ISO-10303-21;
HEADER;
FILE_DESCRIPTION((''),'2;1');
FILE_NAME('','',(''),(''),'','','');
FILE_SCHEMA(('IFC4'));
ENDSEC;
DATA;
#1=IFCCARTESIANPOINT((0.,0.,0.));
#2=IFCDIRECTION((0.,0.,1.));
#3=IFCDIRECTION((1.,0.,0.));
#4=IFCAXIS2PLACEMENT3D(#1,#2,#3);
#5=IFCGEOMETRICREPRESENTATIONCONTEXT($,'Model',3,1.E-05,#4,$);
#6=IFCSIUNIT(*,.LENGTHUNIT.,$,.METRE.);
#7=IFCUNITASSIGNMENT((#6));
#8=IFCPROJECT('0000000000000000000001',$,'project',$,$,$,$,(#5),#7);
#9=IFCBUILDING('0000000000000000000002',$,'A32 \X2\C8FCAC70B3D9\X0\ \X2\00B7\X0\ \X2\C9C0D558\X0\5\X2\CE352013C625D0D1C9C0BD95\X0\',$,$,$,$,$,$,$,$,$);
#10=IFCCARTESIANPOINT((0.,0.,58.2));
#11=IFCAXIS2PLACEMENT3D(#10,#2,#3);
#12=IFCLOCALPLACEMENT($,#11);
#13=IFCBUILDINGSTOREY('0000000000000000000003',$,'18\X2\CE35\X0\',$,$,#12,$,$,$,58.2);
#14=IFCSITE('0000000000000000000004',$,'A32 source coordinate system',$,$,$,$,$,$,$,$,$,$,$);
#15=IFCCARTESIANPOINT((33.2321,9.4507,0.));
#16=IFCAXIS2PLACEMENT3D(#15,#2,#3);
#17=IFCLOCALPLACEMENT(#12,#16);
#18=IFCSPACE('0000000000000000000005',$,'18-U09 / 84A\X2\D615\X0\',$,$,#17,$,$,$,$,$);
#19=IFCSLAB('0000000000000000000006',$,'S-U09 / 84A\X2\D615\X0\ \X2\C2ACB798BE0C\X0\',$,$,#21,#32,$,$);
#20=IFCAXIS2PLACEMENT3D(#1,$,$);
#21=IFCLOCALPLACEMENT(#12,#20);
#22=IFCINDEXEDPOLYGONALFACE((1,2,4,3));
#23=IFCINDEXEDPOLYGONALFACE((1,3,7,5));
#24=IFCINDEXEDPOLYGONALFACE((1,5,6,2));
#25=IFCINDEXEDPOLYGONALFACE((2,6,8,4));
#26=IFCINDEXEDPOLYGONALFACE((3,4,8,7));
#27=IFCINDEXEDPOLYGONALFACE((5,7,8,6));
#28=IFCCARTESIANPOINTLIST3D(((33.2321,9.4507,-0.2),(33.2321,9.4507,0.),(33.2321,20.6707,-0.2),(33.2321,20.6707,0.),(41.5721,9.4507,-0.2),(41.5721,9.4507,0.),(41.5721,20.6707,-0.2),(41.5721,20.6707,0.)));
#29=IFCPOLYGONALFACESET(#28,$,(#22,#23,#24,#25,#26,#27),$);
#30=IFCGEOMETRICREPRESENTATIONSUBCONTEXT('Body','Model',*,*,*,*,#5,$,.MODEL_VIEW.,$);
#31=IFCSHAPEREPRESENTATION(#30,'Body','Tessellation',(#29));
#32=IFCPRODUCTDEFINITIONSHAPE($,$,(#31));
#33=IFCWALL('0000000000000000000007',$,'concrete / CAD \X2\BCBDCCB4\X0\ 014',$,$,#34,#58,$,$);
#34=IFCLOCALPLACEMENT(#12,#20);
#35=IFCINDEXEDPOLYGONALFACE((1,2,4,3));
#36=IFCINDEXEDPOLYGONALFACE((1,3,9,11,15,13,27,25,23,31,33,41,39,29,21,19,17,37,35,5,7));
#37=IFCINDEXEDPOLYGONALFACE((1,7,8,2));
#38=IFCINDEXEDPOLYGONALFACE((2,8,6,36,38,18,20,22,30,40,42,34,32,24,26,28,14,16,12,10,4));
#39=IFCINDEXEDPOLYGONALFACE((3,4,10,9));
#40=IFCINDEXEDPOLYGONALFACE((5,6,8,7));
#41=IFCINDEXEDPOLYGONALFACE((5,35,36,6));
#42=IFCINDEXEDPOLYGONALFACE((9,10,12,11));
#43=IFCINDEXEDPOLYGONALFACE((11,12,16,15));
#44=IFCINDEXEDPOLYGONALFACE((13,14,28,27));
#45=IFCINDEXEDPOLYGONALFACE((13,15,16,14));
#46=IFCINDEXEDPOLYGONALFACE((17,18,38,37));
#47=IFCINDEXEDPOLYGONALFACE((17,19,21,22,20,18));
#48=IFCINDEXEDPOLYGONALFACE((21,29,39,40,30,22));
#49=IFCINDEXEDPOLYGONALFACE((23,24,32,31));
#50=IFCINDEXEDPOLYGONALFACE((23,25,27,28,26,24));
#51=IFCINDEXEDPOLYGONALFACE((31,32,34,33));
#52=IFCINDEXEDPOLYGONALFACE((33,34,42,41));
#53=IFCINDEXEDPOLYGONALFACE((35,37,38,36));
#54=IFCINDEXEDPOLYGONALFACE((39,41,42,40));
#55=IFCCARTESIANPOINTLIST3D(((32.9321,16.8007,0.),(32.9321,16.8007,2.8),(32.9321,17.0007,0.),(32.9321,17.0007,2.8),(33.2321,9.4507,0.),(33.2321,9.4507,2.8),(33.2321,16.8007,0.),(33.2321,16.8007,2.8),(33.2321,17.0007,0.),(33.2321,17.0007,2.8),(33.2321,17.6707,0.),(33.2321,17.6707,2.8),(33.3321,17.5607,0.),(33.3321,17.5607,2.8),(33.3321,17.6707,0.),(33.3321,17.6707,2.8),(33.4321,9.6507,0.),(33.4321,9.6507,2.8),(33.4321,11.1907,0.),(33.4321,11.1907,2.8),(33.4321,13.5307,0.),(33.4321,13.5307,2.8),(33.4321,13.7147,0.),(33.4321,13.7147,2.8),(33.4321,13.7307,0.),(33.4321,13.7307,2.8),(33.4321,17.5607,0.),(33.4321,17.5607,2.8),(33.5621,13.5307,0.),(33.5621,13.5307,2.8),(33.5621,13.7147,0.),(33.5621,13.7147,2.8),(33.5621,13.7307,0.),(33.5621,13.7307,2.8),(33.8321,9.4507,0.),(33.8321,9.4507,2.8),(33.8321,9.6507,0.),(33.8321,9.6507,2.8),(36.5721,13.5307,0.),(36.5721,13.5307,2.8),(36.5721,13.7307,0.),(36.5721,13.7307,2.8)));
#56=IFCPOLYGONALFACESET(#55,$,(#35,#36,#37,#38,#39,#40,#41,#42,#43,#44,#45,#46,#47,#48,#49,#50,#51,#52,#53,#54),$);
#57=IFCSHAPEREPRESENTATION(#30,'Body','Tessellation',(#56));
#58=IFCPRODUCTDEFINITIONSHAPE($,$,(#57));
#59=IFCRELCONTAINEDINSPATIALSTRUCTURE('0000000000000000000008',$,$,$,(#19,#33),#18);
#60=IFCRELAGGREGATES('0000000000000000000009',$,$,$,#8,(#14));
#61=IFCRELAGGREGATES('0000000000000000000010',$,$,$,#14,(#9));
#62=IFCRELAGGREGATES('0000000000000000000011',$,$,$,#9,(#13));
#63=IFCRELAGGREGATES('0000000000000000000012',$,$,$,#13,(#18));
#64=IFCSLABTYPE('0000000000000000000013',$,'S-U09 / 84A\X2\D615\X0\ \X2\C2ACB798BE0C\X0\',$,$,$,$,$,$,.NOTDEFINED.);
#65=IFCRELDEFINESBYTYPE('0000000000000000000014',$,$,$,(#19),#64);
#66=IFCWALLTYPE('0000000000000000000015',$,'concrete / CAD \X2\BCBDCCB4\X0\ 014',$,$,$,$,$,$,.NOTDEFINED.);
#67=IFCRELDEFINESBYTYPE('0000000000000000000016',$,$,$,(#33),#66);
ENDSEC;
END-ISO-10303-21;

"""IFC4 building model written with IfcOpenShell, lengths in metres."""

from ifc_helpers import new_model, si_unit, frame, origin, origin_with_axes, place, context, subcontext, project, spatial, polyline, outline, extrude, source, transform, mapped, type_object, type_shapes, element, save


model = new_model("IFC4")

# Units and contexts
model_context = context("Model", 3, precision=1e-05, world=origin_with_axes())
body_context = subcontext(model_context, "Body", "Model", "MODEL_VIEW")
ifc_project = project(units=[si_unit("LENGTHUNIT", "METRE")], contexts=[model_context])

# Site, building, storey, space
storey_placement = place(None, frame((0.0, 0.0, 58.2), z_axis=(0.0, 0.0, 1.0), x_axis=(1.0, 0.0, 0.0)))
space_placement = place(storey_placement, frame((33.2321, 9.4507, 0.0), z_axis=(0.0, 0.0, 1.0), x_axis=(1.0, 0.0, 0.0)))
site = spatial("IfcSite", under=ifc_project, Name="A32 source coordinate system")
building = spatial("IfcBuilding", under=site, Name="A32 주거동 · 지하5층–옥탑지붕")
storey = spatial("IfcBuildingStorey", under=building, at=storey_placement, Name="18층", Elevation=58.2)
space = spatial("IfcSpace", under=storey, at=space_placement, Name="18-U09 / 84A형")

# Slab
slab_type_1 = type_object("IfcSlabType", Name="S-U09 / 84A형 슬래브", PredefinedType="NOTDEFINED")
shared_shape_1 = source(origin(), body_context, "Body", "SweptSolid", [
    extrude(outline(polyline([(0.0, 11.22), (8.34, 11.22), (8.34, 0.0), (0.0, 0.0), (0.0, 11.22)])), frame((0.0, 0.0, -0.2)), (0.0, 0.0, 1.0), 0.2),
])
type_shapes(slab_type_1, [shared_shape_1])
slab_1_placement = place(space_placement, origin_with_axes())
element("IfcSlab", 1, at=slab_1_placement, inside=space, type_object=slab_type_1, Name="S-U09 / 84A형 슬래브", context=body_context, shape_type="MappedRepresentation", body=[
    mapped(shared_shape_1, transform((0.0, 0.0, 0.0), scale=1.0)),
])

# Wall
wall_type_1 = type_object("IfcWallType", Name="concrete / CAD 벽체 014", PredefinedType="NOTDEFINED")
shared_shape_2 = source(origin(), body_context, "Body", "SweptSolid", [
    extrude(outline(polyline([(3.34, 4.08), (0.33, 4.08), (0.2, 4.08), (0.2, 1.74), (0.2, 0.2), (0.6, 0.2), (0.6, 0.0), (0.0, 0.0), (0.0, 7.35), (-0.3, 7.35), (-0.3, 7.55), (0.0, 7.55), (0.0, 8.22), (0.1, 8.22), (0.1, 8.11), (0.2, 8.11), (0.2, 4.28), (0.2, 4.264), (0.33, 4.264), (0.33, 4.28), (3.34, 4.28), (3.34, 4.08)])), origin(), (0.0, 0.0, 1.0), 2.8),
])
type_shapes(wall_type_1, [shared_shape_2])
wall_1_placement = place(space_placement, origin_with_axes())
element("IfcWall", 2, at=wall_1_placement, inside=space, type_object=wall_type_1, Name="concrete / CAD 벽체 014", context=body_context, shape_type="MappedRepresentation", body=[
    mapped(shared_shape_2, transform((0.0, 0.0, 0.0), scale=1.0)),
])

save(model, "model.ifc")
